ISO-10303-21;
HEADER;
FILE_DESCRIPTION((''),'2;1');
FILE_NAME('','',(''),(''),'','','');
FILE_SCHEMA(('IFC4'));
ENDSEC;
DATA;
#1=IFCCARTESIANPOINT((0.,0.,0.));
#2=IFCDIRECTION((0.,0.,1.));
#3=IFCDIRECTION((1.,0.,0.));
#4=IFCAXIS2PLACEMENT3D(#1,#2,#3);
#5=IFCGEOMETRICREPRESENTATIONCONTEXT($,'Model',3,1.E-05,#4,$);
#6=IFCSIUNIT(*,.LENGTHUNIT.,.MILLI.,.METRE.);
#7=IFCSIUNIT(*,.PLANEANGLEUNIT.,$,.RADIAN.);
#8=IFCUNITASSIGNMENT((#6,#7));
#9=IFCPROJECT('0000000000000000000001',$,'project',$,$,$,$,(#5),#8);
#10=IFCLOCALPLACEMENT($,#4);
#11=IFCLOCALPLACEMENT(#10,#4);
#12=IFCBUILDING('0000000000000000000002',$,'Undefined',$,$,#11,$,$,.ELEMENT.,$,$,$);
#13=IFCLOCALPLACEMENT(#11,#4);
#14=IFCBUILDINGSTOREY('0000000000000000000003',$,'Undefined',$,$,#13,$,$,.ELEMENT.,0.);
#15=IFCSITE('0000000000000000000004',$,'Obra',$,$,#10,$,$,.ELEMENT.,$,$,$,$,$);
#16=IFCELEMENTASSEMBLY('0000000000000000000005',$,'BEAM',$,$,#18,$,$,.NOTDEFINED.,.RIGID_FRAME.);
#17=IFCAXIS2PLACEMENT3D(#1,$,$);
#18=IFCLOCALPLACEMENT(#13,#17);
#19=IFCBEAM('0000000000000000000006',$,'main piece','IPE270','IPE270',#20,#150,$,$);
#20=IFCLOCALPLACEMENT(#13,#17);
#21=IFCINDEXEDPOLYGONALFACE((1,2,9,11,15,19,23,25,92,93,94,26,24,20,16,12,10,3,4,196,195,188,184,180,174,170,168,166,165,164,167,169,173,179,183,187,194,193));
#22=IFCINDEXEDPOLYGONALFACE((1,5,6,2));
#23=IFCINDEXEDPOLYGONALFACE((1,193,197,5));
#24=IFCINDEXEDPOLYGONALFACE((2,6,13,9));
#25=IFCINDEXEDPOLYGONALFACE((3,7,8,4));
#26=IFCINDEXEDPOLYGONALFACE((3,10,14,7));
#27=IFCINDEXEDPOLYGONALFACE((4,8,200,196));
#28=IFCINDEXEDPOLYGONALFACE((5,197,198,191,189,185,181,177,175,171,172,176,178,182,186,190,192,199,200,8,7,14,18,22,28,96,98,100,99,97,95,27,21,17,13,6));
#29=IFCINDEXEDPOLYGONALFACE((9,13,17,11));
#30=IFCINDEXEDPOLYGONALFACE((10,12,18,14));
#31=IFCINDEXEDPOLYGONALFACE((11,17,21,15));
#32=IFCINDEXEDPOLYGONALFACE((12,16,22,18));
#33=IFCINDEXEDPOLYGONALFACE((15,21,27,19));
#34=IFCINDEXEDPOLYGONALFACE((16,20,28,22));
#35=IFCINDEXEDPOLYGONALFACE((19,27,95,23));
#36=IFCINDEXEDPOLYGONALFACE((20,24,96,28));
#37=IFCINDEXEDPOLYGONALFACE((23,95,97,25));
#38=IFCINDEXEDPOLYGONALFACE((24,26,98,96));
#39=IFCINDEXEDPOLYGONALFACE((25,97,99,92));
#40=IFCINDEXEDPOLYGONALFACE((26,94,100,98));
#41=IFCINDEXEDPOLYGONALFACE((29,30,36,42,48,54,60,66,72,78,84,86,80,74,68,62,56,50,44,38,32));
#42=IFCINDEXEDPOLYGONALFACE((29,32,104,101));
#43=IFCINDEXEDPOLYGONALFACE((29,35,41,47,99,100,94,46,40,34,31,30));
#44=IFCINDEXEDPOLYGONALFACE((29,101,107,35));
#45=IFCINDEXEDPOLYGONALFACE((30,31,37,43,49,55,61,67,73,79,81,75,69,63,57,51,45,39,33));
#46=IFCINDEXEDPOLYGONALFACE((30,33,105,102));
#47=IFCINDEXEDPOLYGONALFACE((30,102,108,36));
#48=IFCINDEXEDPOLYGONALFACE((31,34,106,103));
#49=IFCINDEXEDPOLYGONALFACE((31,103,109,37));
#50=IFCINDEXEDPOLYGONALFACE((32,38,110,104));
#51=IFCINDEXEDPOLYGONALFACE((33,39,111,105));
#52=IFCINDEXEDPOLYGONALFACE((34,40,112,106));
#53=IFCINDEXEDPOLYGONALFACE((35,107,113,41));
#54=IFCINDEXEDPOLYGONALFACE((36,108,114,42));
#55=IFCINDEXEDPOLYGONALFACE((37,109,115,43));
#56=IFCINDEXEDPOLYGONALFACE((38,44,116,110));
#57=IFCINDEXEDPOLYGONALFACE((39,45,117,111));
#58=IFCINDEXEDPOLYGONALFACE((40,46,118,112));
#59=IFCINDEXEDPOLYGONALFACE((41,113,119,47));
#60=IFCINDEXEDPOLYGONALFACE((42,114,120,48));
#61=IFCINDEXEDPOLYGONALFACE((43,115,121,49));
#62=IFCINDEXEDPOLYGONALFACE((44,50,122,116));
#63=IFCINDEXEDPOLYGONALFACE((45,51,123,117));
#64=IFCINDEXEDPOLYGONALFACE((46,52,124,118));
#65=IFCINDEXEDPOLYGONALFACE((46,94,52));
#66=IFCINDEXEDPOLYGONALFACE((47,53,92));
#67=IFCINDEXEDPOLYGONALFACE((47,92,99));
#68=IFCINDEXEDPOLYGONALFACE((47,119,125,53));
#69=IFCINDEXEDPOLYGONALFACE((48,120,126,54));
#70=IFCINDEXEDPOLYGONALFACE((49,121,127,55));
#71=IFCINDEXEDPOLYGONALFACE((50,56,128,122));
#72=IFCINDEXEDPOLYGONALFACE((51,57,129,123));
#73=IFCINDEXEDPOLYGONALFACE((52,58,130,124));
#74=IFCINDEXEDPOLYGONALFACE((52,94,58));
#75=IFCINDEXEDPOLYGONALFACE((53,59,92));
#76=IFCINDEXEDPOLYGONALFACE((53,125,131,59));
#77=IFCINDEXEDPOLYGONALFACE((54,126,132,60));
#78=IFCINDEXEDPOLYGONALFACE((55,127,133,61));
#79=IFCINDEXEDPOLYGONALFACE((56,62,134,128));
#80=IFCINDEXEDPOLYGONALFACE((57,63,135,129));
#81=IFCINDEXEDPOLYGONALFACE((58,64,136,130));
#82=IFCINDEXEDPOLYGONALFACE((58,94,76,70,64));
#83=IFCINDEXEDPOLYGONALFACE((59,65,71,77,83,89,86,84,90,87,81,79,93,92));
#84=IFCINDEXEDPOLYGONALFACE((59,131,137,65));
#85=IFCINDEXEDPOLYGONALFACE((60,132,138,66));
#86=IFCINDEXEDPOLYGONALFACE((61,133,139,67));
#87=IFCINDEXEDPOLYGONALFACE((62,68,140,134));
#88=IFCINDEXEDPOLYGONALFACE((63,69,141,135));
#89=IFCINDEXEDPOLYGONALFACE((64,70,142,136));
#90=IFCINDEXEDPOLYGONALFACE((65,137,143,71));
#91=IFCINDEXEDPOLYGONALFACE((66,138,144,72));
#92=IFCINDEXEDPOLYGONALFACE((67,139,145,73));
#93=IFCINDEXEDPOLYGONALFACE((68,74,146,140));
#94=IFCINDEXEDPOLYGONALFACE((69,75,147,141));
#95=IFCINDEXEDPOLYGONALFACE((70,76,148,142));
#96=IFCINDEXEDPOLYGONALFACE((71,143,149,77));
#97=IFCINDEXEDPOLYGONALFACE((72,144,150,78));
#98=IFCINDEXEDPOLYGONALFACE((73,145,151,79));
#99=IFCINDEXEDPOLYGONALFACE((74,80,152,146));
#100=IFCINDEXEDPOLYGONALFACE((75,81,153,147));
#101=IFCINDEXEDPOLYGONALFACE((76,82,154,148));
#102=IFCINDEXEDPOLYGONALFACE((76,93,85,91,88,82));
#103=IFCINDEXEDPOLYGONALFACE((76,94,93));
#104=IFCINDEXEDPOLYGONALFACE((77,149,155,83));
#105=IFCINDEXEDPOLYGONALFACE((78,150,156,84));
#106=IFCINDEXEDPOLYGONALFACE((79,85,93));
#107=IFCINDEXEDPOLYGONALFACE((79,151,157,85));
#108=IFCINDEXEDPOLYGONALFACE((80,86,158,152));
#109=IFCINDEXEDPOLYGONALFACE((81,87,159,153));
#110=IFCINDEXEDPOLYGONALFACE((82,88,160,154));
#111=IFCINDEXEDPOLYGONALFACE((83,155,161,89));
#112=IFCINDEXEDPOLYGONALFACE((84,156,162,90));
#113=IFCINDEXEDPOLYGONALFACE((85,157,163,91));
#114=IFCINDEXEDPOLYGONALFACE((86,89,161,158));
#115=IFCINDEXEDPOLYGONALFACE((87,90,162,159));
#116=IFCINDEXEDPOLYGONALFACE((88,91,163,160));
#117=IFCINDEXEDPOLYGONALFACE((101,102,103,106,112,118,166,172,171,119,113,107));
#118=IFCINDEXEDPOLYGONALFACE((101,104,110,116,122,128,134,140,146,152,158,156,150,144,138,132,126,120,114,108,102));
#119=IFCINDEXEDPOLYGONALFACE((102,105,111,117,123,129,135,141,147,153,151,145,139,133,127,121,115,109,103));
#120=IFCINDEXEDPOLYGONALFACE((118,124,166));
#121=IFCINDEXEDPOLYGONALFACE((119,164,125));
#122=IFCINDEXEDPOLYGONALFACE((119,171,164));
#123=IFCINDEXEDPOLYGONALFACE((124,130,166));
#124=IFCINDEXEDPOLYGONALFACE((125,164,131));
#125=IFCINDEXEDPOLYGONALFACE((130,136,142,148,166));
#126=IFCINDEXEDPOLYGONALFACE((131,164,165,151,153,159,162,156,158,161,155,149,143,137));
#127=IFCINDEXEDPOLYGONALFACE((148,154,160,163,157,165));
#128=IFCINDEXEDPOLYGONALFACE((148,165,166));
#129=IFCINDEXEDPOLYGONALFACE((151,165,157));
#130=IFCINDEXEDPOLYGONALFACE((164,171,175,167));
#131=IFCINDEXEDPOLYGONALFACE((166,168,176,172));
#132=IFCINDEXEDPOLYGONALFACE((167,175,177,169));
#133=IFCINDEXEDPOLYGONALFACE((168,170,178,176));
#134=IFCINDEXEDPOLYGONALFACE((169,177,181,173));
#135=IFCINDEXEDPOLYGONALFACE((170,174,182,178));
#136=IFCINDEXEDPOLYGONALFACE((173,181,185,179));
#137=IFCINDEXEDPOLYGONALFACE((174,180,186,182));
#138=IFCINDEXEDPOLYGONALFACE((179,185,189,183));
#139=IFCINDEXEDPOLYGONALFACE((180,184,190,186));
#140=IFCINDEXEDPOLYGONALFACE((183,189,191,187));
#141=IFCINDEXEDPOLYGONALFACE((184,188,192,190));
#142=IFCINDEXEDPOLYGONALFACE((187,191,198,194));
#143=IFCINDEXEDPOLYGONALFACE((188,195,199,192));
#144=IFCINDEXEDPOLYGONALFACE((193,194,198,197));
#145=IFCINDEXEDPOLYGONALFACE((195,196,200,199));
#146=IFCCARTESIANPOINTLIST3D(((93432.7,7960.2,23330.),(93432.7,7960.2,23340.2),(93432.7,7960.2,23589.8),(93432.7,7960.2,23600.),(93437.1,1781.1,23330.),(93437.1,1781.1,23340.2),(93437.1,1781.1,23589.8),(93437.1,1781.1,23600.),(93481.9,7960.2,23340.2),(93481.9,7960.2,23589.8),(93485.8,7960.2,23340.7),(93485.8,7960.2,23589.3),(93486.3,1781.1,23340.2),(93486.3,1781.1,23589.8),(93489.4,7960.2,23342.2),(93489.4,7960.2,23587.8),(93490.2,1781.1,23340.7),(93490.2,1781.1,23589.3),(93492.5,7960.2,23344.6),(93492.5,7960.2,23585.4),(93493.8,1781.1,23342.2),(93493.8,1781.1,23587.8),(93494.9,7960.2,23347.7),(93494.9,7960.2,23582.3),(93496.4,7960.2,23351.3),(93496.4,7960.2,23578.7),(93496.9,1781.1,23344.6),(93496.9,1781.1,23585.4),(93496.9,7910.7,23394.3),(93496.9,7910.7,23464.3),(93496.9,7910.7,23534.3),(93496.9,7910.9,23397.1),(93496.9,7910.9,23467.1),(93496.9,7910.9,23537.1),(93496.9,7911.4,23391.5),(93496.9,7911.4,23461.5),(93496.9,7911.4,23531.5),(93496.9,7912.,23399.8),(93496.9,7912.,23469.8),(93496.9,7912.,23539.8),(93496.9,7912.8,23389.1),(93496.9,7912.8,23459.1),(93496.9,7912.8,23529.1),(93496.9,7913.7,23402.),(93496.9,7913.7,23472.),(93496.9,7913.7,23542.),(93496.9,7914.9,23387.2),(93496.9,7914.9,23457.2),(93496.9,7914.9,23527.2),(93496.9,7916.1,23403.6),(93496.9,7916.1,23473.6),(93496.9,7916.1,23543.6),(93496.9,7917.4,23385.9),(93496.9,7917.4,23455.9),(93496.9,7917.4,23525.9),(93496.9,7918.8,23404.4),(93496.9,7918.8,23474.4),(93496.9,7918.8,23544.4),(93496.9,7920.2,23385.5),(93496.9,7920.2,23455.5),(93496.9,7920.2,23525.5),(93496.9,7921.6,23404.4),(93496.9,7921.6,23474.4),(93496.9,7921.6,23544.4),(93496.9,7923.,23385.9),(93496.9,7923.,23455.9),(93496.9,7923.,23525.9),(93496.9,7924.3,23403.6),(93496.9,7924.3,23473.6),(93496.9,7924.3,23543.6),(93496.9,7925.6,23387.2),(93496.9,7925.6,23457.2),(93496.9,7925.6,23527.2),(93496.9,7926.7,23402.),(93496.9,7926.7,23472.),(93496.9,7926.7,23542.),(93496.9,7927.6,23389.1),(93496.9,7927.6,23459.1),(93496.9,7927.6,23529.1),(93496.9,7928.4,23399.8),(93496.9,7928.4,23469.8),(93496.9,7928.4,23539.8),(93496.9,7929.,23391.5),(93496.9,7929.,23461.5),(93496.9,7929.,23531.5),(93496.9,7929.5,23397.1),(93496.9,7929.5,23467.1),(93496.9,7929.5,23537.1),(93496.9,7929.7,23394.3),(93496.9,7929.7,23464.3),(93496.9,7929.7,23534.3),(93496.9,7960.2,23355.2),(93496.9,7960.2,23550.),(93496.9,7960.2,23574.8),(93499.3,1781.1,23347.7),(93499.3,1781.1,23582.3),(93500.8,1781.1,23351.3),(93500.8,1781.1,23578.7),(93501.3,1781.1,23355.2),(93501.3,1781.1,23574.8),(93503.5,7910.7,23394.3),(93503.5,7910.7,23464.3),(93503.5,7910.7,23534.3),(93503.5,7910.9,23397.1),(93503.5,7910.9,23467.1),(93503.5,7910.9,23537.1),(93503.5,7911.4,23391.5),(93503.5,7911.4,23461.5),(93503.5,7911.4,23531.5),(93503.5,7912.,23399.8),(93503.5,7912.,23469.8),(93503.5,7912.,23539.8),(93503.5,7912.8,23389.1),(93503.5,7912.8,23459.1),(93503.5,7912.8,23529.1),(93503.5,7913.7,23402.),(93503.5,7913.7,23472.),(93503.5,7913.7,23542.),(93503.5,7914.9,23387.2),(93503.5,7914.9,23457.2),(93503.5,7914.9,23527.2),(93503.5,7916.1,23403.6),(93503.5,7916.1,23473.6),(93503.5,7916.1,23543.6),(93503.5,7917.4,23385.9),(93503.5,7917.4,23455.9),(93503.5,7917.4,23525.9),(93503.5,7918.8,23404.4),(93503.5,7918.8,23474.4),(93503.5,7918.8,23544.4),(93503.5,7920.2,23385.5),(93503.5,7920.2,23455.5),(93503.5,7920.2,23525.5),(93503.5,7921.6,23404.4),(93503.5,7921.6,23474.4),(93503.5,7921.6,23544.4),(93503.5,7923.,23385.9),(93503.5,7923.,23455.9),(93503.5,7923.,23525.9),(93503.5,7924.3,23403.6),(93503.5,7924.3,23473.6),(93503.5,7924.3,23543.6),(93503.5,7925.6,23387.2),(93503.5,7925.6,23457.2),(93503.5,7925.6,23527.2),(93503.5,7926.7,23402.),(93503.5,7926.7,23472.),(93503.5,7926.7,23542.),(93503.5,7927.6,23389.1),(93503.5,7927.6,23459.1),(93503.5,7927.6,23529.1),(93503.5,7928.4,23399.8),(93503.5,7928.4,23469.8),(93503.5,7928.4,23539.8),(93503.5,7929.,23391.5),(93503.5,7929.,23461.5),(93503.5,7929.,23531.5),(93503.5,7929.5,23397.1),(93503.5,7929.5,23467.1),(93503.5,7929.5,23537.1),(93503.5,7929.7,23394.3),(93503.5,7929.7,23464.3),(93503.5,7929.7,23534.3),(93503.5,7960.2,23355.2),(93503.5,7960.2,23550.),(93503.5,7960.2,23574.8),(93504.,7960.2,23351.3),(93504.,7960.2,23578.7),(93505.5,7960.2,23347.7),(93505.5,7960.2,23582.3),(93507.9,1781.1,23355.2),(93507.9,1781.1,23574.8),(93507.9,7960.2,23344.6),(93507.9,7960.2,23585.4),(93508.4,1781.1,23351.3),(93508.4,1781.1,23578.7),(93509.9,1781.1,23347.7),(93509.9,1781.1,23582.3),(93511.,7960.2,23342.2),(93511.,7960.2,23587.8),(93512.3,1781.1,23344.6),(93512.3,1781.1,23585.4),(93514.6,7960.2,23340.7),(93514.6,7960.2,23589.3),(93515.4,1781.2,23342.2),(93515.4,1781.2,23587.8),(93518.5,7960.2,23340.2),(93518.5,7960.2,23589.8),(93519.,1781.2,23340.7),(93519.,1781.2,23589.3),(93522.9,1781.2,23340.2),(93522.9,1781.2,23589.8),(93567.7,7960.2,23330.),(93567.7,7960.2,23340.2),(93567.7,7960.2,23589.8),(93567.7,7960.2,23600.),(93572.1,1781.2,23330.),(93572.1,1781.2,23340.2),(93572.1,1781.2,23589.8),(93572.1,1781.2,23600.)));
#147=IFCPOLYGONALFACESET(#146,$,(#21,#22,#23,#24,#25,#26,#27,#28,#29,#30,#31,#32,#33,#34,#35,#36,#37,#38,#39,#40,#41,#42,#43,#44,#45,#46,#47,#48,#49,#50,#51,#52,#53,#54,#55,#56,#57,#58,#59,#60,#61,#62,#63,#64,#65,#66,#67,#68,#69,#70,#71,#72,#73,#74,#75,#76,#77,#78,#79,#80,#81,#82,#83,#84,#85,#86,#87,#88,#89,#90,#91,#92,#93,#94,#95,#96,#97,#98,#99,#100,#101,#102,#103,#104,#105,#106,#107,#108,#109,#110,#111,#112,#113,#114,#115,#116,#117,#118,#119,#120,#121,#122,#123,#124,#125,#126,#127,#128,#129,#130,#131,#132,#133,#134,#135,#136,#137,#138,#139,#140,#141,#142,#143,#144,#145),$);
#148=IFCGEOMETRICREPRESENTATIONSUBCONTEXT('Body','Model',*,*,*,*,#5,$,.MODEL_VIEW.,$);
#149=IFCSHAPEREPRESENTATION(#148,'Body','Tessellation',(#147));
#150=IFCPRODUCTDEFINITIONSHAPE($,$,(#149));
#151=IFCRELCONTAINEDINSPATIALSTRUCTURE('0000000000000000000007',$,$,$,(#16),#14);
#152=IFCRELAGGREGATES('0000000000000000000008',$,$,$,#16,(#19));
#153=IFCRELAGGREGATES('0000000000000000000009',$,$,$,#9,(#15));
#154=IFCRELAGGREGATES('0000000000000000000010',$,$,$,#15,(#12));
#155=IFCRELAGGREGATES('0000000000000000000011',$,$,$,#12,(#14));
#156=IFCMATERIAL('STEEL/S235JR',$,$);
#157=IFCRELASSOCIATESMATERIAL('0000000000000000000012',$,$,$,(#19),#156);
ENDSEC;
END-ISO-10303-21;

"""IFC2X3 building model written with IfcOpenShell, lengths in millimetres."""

from ifc_helpers import new_model, si_unit, frame, origin_with_axes, origin_2d_with_axis, place, context, subcontext, project, spatial, rectangle, circle, i_section, extrude, clip, halfspace, source, transform, mapped, material, element, aggregate, save


model = new_model("IFC2X3")

# Units and contexts
model_context = context("Model", 3, precision=1e-05, world=origin_with_axes())
body_context = subcontext(model_context, "Body", "Model", "MODEL_VIEW")
ifc_project = project(units=[si_unit("LENGTHUNIT", "METRE", prefix="MILLI"), si_unit("PLANEANGLEUNIT", "RADIAN")], contexts=[model_context])

# Site, building, storey
site_placement = place(None, origin_with_axes())
site = spatial("IfcSite", under=ifc_project, at=site_placement, Name="Obra", CompositionType="ELEMENT")
building_placement = place(site_placement, origin_with_axes())
building = spatial("IfcBuilding", under=site, at=building_placement, Name="Undefined", CompositionType="ELEMENT")
storey_placement = place(building_placement, origin_with_axes())
storey = spatial("IfcBuildingStorey", under=building, at=storey_placement, Name="Undefined", CompositionType="ELEMENT", Elevation=0.0)

# Shared definitions
ifc_material_1 = material(Name="STEEL/S235JR")

# Element assembly, beam, openings
assembly_1_placement = place(storey_placement, origin_with_axes())
assembly_1 = element("IfcElementAssembly", 1, at=assembly_1_placement, inside=storey, Name="BEAM", AssemblyPlace="NOTDEFINED", PredefinedType="RIGID_FRAME")
beam_1_placement = place(assembly_1_placement, frame((93500.2, 7957.4, 23465.0), z_axis=(0.0, 0.0, 1.0), x_axis=(0.000705, -1.0, 0.0)))
beam_1 = element("IfcBeam", 2, at=beam_1_placement, material=ifc_material_1, Name="main piece", Description="IPE270", ObjectType="IPE270", context=body_context, shape_type="Clipping", body=[
    clip(extrude(i_section(OverallWidth=135.0, OverallDepth=270.0, WebThickness=6.6, FlangeThickness=10.2, FilletRadius=15.0, at=origin_2d_with_axis()), frame((6176.3, 0.0, 0.0), z_axis=(-1.0, 0.0, 0.0), x_axis=(0.0, -1.0, 0.0)), (0.0, 0.0, 1.0), 6179.2), halfspace(frame((-2.8, -0.1, -235.0), z_axis=(1.0, -0.000705, 0.0), x_axis=(-0.000705, -1.0, 0.0)), True)),
])
opening_1_placement = place(assembly_1_placement, frame((93500.2, 7957.4, 23465.0), z_axis=(0.0, 0.0, 1.0), x_axis=(0.000705, -1.0, 0.0)))
element("IfcOpeningElement", 3, at=opening_1_placement, cuts=beam_1, ObjectType="Recess", context=body_context, shape_type="SweptSolid", body=[
    extrude(rectangle(XDim=51.0, YDim=156.0, at=origin_2d_with_axis()), frame((-80.8, -68.4, 110.5), z_axis=(0.000705, 1.0, 0.0), x_axis=(0.0, 0.0, -1.0)), (0.0, 0.0, 1.0), 141.4),
])
shared_shape_1 = source(origin_with_axes(), body_context, "Body", "SweptSolid", [
    extrude(circle(Radius=9.5, at=origin_2d_with_axis()), frame((0.0, -3.3, 0.0), z_axis=(0.0, 1.0, 0.0), x_axis=(1.0, 0.0, 0.0)), (0.0, 0.0, 1.0), 6.8),
])
opening_2_placement = place(assembly_1_placement, frame((93500.1, 7960.2, 23570.0), z_axis=(0.0, -1.0, 0.0), x_axis=(0.0, 0.0, -1.0)))
element("IfcOpeningElement", 4, at=opening_2_placement, cuts=beam_1, ObjectType="Opening", context=body_context, shape_type="MappedRepresentation", body=[
    mapped(shared_shape_1, transform((35.0, 0.0, 40.0))),
    mapped(shared_shape_1, transform((105.0, 0.0, 40.0))),
    mapped(shared_shape_1, transform((175.0, 0.0, 40.0))),
])
aggregate(assembly_1, [beam_1])

save(model, "model.ifc")
